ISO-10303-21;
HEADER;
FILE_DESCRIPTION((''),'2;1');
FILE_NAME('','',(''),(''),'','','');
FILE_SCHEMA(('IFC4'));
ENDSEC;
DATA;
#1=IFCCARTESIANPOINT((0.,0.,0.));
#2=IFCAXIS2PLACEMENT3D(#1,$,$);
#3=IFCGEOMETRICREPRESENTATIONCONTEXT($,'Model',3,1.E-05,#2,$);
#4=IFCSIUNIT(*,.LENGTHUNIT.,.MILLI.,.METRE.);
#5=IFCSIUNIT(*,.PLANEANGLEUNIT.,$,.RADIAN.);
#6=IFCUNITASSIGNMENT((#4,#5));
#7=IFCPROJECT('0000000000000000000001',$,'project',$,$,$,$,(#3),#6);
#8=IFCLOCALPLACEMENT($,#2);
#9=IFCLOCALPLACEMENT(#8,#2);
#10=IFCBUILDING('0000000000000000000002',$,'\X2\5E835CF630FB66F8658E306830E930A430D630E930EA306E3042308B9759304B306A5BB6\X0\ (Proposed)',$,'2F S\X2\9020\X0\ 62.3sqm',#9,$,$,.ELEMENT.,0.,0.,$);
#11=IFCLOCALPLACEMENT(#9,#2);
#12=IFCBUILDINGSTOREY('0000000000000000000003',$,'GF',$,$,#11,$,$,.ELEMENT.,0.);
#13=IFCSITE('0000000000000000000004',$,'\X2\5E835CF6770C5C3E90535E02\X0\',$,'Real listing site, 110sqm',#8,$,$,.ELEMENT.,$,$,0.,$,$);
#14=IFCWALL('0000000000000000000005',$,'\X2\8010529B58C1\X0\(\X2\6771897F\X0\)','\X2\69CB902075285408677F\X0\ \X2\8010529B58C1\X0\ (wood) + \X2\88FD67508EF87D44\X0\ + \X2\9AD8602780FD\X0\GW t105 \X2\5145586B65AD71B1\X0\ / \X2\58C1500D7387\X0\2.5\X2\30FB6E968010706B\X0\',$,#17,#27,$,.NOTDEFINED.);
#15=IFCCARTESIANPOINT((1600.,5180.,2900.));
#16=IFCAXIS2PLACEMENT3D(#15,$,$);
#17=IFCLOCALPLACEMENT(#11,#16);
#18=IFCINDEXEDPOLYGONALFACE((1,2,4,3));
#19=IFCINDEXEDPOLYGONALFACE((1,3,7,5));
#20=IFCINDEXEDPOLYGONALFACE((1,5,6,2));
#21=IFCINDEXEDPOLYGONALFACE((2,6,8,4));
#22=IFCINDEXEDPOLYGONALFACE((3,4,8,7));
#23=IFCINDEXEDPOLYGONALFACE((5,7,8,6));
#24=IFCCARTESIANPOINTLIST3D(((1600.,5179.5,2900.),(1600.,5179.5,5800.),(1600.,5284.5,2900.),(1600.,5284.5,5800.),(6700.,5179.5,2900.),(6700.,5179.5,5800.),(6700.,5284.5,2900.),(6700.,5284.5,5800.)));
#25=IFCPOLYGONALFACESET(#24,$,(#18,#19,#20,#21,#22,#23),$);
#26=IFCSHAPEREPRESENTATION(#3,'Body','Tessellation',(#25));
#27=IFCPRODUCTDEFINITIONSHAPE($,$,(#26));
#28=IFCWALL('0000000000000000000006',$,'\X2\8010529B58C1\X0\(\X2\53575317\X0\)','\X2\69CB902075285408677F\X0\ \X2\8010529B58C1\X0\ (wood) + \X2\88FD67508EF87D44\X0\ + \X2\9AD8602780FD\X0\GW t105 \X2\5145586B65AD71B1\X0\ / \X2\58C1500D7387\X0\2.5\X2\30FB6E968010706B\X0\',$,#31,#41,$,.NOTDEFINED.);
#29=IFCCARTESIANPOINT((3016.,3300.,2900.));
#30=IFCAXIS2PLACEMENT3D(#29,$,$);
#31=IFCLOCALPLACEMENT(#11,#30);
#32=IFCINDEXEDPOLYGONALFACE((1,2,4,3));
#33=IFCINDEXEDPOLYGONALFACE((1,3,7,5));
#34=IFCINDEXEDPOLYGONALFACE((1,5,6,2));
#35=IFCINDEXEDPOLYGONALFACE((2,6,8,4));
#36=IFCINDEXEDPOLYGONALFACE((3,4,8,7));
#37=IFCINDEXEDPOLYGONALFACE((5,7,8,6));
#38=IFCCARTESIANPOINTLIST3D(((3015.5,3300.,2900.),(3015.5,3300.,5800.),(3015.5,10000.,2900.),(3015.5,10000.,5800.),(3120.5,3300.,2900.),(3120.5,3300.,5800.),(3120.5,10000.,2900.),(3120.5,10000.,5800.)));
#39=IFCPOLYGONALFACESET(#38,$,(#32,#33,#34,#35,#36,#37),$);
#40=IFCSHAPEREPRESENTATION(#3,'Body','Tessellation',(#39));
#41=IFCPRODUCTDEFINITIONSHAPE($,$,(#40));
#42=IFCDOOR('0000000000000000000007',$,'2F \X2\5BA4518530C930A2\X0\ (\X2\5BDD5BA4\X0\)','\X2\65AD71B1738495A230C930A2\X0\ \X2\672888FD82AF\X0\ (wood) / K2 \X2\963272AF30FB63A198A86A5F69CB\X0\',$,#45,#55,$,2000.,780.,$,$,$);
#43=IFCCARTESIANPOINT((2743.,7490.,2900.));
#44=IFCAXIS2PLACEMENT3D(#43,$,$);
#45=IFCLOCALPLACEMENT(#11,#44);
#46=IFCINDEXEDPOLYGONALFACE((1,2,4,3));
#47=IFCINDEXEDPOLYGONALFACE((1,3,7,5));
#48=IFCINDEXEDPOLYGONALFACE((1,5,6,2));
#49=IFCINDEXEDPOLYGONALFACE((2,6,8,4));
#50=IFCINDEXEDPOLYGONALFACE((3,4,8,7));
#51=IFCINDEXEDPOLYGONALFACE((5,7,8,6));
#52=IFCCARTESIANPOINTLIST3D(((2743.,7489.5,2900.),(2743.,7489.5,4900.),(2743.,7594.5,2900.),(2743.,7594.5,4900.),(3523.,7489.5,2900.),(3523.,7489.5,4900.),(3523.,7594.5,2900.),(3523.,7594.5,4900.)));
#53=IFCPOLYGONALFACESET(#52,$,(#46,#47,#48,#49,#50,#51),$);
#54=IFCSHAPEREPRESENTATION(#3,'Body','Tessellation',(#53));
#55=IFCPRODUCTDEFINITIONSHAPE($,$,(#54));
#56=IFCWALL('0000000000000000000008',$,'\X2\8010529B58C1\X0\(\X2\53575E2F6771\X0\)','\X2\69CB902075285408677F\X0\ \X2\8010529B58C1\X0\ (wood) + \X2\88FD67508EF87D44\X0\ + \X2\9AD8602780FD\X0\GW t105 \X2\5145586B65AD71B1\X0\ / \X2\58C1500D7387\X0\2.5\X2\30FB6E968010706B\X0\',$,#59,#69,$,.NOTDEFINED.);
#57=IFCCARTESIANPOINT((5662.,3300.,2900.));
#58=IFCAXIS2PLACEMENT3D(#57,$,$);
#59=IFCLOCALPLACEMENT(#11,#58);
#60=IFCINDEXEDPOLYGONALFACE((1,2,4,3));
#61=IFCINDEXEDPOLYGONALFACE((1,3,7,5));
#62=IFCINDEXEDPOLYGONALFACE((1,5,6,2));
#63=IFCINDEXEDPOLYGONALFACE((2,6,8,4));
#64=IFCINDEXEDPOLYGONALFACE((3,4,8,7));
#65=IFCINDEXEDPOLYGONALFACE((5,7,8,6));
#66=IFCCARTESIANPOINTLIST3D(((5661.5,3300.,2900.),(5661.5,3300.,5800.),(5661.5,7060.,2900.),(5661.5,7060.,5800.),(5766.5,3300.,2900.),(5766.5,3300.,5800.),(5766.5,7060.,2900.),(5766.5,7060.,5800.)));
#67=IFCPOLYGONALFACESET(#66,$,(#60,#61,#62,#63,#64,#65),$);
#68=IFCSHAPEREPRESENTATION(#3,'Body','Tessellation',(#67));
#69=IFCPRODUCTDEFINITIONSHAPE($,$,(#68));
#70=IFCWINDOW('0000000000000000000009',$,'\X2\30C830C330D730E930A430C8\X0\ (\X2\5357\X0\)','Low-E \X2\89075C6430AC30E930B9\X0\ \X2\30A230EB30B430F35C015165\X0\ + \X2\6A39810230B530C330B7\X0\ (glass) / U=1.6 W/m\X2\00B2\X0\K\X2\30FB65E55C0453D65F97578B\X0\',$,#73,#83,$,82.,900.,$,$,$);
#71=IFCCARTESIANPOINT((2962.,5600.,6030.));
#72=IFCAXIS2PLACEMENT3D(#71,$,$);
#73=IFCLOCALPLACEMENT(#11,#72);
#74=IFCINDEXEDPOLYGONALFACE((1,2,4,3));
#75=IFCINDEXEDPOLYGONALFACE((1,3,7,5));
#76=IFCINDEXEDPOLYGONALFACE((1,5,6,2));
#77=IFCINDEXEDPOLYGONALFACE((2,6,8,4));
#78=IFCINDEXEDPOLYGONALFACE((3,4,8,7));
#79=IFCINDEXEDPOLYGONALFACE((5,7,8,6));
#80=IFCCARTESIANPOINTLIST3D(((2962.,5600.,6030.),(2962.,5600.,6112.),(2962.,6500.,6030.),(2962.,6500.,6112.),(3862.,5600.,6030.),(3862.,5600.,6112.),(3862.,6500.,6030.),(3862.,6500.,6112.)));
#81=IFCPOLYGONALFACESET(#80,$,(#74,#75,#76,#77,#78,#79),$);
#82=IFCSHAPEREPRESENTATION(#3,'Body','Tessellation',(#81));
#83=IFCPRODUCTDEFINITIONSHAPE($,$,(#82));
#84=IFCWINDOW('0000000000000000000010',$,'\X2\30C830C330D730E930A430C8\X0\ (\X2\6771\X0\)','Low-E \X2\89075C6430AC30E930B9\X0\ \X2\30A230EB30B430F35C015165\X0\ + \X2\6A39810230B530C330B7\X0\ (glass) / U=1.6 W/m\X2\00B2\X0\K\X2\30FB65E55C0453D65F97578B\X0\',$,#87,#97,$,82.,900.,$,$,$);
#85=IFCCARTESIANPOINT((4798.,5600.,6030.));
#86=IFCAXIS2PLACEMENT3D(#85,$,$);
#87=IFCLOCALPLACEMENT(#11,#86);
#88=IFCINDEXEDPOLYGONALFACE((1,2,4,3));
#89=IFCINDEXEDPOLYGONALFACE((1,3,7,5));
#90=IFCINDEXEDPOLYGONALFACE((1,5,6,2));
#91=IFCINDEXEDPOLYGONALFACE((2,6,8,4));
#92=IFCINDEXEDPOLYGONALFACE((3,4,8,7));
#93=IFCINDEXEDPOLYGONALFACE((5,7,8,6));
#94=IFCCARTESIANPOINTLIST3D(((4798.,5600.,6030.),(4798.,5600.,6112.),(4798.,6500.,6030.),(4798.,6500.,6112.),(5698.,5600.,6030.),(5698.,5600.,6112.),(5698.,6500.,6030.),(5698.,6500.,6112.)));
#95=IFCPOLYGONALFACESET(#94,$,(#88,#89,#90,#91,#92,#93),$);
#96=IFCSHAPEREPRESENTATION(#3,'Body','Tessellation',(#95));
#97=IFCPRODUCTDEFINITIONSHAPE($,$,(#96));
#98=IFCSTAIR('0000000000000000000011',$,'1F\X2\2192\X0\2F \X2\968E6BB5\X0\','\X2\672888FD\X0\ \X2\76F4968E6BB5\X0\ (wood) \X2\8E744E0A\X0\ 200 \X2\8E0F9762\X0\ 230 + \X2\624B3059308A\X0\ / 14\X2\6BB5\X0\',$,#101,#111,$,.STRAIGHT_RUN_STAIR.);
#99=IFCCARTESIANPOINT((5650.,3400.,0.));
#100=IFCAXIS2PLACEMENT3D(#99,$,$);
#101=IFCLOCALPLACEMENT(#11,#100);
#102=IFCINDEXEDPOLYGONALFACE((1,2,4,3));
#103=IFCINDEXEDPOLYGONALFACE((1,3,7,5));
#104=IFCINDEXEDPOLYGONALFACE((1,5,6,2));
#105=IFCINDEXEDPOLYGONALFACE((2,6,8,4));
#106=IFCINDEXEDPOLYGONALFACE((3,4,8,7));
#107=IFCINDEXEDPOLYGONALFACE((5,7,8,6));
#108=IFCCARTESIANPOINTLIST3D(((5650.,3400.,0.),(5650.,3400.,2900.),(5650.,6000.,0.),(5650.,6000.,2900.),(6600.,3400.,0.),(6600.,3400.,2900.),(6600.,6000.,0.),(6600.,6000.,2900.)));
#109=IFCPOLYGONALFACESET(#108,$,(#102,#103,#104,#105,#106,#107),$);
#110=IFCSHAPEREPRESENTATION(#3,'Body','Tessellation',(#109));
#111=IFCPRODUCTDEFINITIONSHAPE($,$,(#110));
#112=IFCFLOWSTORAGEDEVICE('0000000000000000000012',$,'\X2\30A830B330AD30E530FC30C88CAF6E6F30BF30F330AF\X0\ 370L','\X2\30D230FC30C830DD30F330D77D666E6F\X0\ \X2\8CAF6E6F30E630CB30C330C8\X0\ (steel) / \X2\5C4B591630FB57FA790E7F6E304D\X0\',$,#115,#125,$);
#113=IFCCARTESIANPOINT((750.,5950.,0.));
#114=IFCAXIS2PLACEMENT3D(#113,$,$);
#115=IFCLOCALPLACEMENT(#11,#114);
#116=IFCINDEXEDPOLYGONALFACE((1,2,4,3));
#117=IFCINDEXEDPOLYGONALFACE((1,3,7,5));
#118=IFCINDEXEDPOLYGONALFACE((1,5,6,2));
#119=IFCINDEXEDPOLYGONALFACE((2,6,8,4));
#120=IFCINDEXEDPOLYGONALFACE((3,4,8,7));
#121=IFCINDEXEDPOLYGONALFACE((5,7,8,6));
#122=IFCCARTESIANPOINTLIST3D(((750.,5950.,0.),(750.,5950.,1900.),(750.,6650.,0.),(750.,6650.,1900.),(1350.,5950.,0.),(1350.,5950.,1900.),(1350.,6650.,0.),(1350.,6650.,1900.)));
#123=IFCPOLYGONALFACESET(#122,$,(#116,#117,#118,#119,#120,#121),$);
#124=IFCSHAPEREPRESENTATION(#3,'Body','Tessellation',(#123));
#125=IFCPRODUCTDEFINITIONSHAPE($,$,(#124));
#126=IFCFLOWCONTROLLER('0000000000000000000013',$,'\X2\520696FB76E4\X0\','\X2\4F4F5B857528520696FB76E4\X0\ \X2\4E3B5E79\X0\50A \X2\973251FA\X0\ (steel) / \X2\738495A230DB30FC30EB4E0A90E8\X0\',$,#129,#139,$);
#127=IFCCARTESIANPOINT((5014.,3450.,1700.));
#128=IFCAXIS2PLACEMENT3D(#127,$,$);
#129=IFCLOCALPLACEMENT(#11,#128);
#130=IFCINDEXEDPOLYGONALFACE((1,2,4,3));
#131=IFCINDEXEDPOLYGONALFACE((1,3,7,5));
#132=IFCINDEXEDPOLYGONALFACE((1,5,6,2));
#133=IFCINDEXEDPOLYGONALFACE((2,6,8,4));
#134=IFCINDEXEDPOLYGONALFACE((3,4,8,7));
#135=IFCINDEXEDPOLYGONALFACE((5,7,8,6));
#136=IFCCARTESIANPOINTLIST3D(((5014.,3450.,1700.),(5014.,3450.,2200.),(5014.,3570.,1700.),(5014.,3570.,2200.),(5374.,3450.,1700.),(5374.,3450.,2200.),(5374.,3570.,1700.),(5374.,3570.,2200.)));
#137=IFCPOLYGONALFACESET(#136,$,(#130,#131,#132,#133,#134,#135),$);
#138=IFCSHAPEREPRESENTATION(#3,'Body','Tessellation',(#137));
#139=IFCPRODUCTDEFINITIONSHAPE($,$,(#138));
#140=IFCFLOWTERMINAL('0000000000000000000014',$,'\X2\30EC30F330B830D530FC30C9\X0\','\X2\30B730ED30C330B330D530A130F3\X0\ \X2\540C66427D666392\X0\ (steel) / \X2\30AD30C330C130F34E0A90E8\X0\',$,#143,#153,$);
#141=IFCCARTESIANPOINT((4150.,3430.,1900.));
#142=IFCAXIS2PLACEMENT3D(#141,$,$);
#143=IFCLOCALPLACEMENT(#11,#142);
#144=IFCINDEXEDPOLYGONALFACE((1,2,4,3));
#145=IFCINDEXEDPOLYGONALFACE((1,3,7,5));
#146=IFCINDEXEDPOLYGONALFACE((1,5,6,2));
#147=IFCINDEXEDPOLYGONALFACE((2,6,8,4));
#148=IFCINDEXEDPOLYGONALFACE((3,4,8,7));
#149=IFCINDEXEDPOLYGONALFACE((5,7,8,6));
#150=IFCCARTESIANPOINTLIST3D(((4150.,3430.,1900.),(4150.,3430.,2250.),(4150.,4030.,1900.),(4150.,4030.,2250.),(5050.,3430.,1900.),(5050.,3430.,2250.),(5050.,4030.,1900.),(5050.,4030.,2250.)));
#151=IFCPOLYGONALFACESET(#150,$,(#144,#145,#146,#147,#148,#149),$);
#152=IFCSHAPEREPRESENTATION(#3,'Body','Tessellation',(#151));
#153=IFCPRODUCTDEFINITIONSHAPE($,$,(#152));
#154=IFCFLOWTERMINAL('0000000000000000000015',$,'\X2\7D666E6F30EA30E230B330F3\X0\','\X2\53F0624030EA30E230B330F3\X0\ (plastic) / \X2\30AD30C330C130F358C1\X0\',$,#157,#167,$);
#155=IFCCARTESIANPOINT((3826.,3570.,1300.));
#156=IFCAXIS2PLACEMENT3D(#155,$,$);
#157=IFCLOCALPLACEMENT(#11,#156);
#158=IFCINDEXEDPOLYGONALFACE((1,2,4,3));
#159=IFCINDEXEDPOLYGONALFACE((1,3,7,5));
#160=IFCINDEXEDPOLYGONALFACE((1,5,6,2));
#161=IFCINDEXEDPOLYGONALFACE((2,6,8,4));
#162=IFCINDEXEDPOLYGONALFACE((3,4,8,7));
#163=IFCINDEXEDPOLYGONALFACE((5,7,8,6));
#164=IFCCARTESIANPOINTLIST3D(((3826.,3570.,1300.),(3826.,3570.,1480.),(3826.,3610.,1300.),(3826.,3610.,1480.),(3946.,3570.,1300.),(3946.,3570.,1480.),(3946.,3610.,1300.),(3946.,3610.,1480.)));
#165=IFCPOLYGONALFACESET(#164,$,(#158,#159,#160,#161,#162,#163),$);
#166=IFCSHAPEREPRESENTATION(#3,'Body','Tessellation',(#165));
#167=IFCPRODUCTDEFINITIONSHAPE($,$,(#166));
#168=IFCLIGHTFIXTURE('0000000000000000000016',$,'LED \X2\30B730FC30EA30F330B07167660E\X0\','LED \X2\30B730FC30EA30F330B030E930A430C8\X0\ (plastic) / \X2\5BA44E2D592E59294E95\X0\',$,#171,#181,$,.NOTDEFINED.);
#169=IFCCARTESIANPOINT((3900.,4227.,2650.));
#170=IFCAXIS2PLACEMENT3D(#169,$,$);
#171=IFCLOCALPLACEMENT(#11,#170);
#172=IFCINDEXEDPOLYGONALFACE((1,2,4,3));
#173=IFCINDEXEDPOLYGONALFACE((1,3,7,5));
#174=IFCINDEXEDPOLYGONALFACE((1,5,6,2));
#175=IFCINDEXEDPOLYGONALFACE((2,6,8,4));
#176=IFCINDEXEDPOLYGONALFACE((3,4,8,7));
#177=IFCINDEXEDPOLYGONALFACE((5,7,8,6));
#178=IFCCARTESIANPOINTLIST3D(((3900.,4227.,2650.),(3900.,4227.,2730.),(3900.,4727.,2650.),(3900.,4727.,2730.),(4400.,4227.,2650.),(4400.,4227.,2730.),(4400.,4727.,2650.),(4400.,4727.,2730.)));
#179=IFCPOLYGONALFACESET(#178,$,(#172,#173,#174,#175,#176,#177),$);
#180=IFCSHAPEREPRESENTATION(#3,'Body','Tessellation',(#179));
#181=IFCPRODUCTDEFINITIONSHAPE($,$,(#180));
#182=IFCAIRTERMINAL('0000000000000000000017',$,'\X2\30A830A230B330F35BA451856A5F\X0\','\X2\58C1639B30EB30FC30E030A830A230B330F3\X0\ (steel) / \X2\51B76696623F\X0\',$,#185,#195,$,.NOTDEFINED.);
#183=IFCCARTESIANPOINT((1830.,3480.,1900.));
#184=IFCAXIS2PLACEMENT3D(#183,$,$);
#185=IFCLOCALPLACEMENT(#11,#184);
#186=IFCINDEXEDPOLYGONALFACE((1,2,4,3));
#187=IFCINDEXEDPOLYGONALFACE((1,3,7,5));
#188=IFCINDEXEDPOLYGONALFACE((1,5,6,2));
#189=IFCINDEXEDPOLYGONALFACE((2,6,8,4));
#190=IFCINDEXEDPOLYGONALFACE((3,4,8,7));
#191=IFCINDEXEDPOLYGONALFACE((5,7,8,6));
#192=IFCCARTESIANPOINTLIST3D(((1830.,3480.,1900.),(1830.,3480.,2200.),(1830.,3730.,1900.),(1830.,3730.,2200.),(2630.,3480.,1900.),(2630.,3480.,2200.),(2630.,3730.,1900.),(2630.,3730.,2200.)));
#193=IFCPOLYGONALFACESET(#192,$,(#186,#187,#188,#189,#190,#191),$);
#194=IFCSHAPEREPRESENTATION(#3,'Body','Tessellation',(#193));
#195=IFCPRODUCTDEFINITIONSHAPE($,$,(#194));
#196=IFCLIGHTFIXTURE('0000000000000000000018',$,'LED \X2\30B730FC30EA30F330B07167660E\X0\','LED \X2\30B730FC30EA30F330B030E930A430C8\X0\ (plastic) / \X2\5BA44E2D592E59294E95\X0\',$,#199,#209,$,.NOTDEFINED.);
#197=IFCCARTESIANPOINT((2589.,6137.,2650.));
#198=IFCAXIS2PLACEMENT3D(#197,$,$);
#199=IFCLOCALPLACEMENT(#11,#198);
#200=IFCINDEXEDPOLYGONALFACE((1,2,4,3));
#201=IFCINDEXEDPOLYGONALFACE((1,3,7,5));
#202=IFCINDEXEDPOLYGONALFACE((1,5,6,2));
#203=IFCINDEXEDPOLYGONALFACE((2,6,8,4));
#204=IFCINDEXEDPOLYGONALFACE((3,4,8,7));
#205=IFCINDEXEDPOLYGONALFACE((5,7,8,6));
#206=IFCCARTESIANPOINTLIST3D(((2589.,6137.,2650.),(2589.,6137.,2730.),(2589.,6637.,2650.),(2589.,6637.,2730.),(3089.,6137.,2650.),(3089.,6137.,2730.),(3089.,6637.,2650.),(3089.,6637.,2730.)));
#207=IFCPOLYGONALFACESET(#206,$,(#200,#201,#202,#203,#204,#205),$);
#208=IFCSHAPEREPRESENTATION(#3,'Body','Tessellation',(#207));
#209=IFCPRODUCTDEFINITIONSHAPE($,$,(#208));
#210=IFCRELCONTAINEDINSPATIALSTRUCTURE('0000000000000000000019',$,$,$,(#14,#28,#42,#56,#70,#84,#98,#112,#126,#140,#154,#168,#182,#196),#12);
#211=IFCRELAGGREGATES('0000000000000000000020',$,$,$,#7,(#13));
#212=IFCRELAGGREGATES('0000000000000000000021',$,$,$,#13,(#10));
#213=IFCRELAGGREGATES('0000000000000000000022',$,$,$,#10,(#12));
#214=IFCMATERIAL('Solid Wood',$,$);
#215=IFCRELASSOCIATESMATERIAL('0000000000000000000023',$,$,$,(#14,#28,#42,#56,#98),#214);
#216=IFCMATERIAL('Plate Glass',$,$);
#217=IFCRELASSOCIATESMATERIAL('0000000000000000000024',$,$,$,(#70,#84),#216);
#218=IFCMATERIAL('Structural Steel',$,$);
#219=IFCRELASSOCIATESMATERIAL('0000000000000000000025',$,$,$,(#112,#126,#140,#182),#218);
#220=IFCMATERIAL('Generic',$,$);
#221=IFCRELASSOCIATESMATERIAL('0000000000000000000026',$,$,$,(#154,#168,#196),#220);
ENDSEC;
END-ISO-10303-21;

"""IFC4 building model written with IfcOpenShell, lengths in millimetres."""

from ifc_helpers import new_model, si_unit, frame, frame_2d, origin, place, context, project, spatial, rectangle, extrude, material, element, fill, save


model = new_model("IFC4")

# Units and contexts
model_context = context("Model", 3, precision=1e-05, world=origin())
ifc_project = project(units=[si_unit("LENGTHUNIT", "METRE", prefix="MILLI"), si_unit("PLANEANGLEUNIT", "RADIAN")], contexts=[model_context])

# Site, building, storey
site_placement = place(None, origin())
site = spatial("IfcSite", under=ifc_project, at=site_placement, Name="広島県尾道市", ObjectType="Real listing site, 110sqm", CompositionType="ELEMENT", RefElevation=0.0)
building_placement = place(site_placement, origin())
building = spatial("IfcBuilding", under=site, at=building_placement, Name="広島・書斎とライブラリのある静かな家 (Proposed)", ObjectType="2F S造 62.3sqm", CompositionType="ELEMENT", ElevationOfRefHeight=0.0, ElevationOfTerrain=0.0)
storey_placement = place(building_placement, origin())
storey = spatial("IfcBuildingStorey", under=building, at=storey_placement, Name="GF", CompositionType="ELEMENT", Elevation=0.0)

# Shared definitions
ifc_material_1 = material(Name="Solid Wood")

# Wall
wall_1_placement = place(storey_placement, frame((1600.0, 5180.0, 2900.0)))
element("IfcWall", 1, at=wall_1_placement, inside=storey, material=ifc_material_1, Name="耐力壁(東西)", Description="構造用合板 耐力壁 (wood) + 製材軸組 + 高性能GW t105 充填断熱 / 壁倍率2.5・準耐火", PredefinedType="NOTDEFINED", context=model_context, shape_type="SweptSolid", body=[
    extrude(rectangle(XDim=5100.0, YDim=105.0, at=frame_2d((2550.0, 52.0))), frame((1600.0, 5180.0, 2900.0)), (0.0, 0.0, 1.0), 2900.0),
])

# Wall, opening, door
wall_2_placement = place(storey_placement, frame((3016.0, 3300.0, 2900.0)))
wall_2 = element("IfcWall", 2, at=wall_2_placement, inside=storey, material=ifc_material_1, Name="耐力壁(南北)", Description="構造用合板 耐力壁 (wood) + 製材軸組 + 高性能GW t105 充填断熱 / 壁倍率2.5・準耐火", PredefinedType="NOTDEFINED", context=model_context, shape_type="SweptSolid", body=[
    extrude(rectangle(XDim=105.0, YDim=6700.0, at=frame_2d((52.0, 3350.0))), frame((3016.0, 3300.0, 2900.0)), (0.0, 0.0, 1.0), 2900.0),
])
opening_placement = place(storey_placement, frame((2743.0, 7490.0, 2900.0)))
opening = element("IfcOpeningElement", 3, at=opening_placement, cuts=wall_2, PredefinedType="NOTDEFINED", context=model_context, shape_type="SweptSolid", body=[
    extrude(rectangle(XDim=780.0, YDim=105.0, at=frame_2d((390.0, 52.0))), frame((2743.0, 7490.0, 2900.0)), (0.0, 0.0, 1.0), 2000.0),
])
door_placement = place(storey_placement, frame((2743.0, 7490.0, 2900.0)))
door = element("IfcDoor", 4, at=door_placement, inside=storey, material=ifc_material_1, Name="2F 室内ドア (寝室)", Description="断熱玄関ドア 木製芯 (wood) / K2 防犯・採風機構", OverallHeight=2000.0, OverallWidth=780.0, context=model_context, shape_type="SweptSolid", body=[
    extrude(rectangle(XDim=780.0, YDim=105.0, at=frame_2d((390.0, 52.0))), frame((2743.0, 7490.0, 2900.0)), (0.0, 0.0, 1.0), 2000.0),
])
fill(opening, door)

# Wall
wall_3_placement = place(storey_placement, frame((5662.0, 3300.0, 2900.0)))
element("IfcWall", 5, at=wall_3_placement, inside=storey, material=ifc_material_1, Name="耐力壁(南帯東)", Description="構造用合板 耐力壁 (wood) + 製材軸組 + 高性能GW t105 充填断熱 / 壁倍率2.5・準耐火", PredefinedType="NOTDEFINED", context=model_context, shape_type="SweptSolid", body=[
    extrude(rectangle(XDim=105.0, YDim=3760.0, at=frame_2d((52.0, 1880.0))), frame((5662.0, 3300.0, 2900.0)), (0.0, 0.0, 1.0), 2900.0),
])

# Windows
ifc_material_2 = material(Name="Plate Glass")
window_1_placement = place(storey_placement, frame((2962.0, 5600.0, 6030.0)))
element("IfcWindow", 6, at=window_1_placement, inside=storey, material=ifc_material_2, Name="トップライト (南)", Description="Low-E 複層ガラス アルゴン封入 + 樹脂サッシ (glass) / U=1.6 W/m²K・日射取得型", OverallHeight=82.0, OverallWidth=900.0, context=model_context, shape_type="SweptSolid", body=[
    extrude(rectangle(XDim=900.0, YDim=900.0, at=frame_2d((450.0, 450.0))), frame((2962.0, 5600.0, 6030.0)), (0.0, 0.0, 1.0), 82.0),
])
window_2_placement = place(storey_placement, frame((4798.0, 5600.0, 6030.0)))
element("IfcWindow", 7, at=window_2_placement, inside=storey, material=ifc_material_2, Name="トップライト (東)", Description="Low-E 複層ガラス アルゴン封入 + 樹脂サッシ (glass) / U=1.6 W/m²K・日射取得型", OverallHeight=82.0, OverallWidth=900.0, context=model_context, shape_type="SweptSolid", body=[
    extrude(rectangle(XDim=900.0, YDim=900.0, at=frame_2d((450.0, 450.0))), frame((4798.0, 5600.0, 6030.0)), (0.0, 0.0, 1.0), 82.0),
])

# Stair
stair_placement = place(storey_placement, frame((5650.0, 3400.0, 0.0)))
element("IfcStair", 8, at=stair_placement, inside=storey, material=ifc_material_1, Name="1F→2F 階段", Description="木製 直階段 (wood) 蹴上 200 踏面 230 + 手すり / 14段", PredefinedType="STRAIGHT_RUN_STAIR", context=model_context, shape_type="SweptSolid", body=[
    extrude(rectangle(XDim=950.0, YDim=2600.0, at=frame_2d((475.0, 1300.0))), frame((5650.0, 3400.0, 0.0)), (0.0, 0.0, 1.0), 2900.0),
])

# Flow storage device
ifc_material_3 = material(Name="Structural Steel")
flow_storage_device_1_placement = place(storey_placement, frame((750.0, 5950.0, 0.0)))
element("IfcFlowStorageDevice", 9, at=flow_storage_device_1_placement, inside=storey, material=ifc_material_3, Name="エコキュート貯湯タンク 370L", Description="ヒートポンプ給湯 貯湯ユニット (steel) / 屋外・基礎置き", context=model_context, shape_type="SweptSolid", body=[
    extrude(rectangle(XDim=600.0, YDim=700.0, at=frame_2d((300.0, 350.0))), frame((750.0, 5950.0, 0.0)), (0.0, 0.0, 1.0), 1900.0),
])

# Flow controller
flow_controller_placement = place(storey_placement, frame((5014.0, 3450.0, 1700.0)))
element("IfcFlowController", 10, at=flow_controller_placement, inside=storey, material=ifc_material_3, Name="分電盤", Description="住宅用分電盤 主幹50A 露出 (steel) / 玄関ホール上部", context=model_context, shape_type="SweptSolid", body=[
    extrude(rectangle(XDim=360.0, YDim=120.0, at=frame_2d((180.0, 60.0))), frame((5014.0, 3450.0, 1700.0)), (0.0, 0.0, 1.0), 500.0),
])

# Flow terminals
flow_terminal_1_placement = place(storey_placement, frame((4150.0, 3430.0, 1900.0)))
element("IfcFlowTerminal", 11, at=flow_terminal_1_placement, inside=storey, material=ifc_material_3, Name="レンジフード", Description="シロッコファン 同時給排 (steel) / キッチン上部", context=model_context, shape_type="SweptSolid", body=[
    extrude(rectangle(XDim=900.0, YDim=600.0, at=frame_2d((450.0, 300.0))), frame((4150.0, 3430.0, 1900.0)), (0.0, 0.0, 1.0), 350.0),
])
ifc_material_4 = material(Name="Generic")
flow_terminal_2_placement = place(storey_placement, frame((3826.0, 3570.0, 1300.0)))
element("IfcFlowTerminal", 12, at=flow_terminal_2_placement, inside=storey, material=ifc_material_4, Name="給湯リモコン", Description="台所リモコン (plastic) / キッチン壁", context=model_context, shape_type="SweptSolid", body=[
    extrude(rectangle(XDim=120.0, YDim=40.0, at=frame_2d((60.0, 20.0))), frame((3826.0, 3570.0, 1300.0)), (0.0, 0.0, 1.0), 180.0),
])

# Light fixture
light_fixture_1_placement = place(storey_placement, frame((3900.0, 4227.0, 2650.0)))
element("IfcLightFixture", 13, at=light_fixture_1_placement, inside=storey, material=ifc_material_4, Name="LED シーリング照明", Description="LED シーリングライト (plastic) / 室中央天井", PredefinedType="NOTDEFINED", context=model_context, shape_type="SweptSolid", body=[
    extrude(rectangle(XDim=500.0, YDim=500.0, at=frame_2d((250.0, 250.0))), frame((3900.0, 4227.0, 2650.0)), (0.0, 0.0, 1.0), 80.0),
])

# Air terminal
air_terminal_1_placement = place(storey_placement, frame((1830.0, 3480.0, 1900.0)))
element("IfcAirTerminal", 14, at=air_terminal_1_placement, inside=storey, material=ifc_material_3, Name="エアコン室内機", Description="壁掛ルームエアコン (steel) / 冷暖房", PredefinedType="NOTDEFINED", context=model_context, shape_type="SweptSolid", body=[
    extrude(rectangle(XDim=800.0, YDim=250.0, at=frame_2d((400.0, 125.0))), frame((1830.0, 3480.0, 1900.0)), (0.0, 0.0, 1.0), 300.0),
])

# Light fixture
light_fixture_2_placement = place(storey_placement, frame((2589.0, 6137.0, 2650.0)))
element("IfcLightFixture", 15, at=light_fixture_2_placement, inside=storey, material=ifc_material_4, Name="LED シーリング照明", Description="LED シーリングライト (plastic) / 室中央天井", PredefinedType="NOTDEFINED", context=model_context, shape_type="SweptSolid", body=[
    extrude(rectangle(XDim=500.0, YDim=500.0, at=frame_2d((250.0, 250.0))), frame((2589.0, 6137.0, 2650.0)), (0.0, 0.0, 1.0), 80.0),
])

save(model, "model.ifc")
